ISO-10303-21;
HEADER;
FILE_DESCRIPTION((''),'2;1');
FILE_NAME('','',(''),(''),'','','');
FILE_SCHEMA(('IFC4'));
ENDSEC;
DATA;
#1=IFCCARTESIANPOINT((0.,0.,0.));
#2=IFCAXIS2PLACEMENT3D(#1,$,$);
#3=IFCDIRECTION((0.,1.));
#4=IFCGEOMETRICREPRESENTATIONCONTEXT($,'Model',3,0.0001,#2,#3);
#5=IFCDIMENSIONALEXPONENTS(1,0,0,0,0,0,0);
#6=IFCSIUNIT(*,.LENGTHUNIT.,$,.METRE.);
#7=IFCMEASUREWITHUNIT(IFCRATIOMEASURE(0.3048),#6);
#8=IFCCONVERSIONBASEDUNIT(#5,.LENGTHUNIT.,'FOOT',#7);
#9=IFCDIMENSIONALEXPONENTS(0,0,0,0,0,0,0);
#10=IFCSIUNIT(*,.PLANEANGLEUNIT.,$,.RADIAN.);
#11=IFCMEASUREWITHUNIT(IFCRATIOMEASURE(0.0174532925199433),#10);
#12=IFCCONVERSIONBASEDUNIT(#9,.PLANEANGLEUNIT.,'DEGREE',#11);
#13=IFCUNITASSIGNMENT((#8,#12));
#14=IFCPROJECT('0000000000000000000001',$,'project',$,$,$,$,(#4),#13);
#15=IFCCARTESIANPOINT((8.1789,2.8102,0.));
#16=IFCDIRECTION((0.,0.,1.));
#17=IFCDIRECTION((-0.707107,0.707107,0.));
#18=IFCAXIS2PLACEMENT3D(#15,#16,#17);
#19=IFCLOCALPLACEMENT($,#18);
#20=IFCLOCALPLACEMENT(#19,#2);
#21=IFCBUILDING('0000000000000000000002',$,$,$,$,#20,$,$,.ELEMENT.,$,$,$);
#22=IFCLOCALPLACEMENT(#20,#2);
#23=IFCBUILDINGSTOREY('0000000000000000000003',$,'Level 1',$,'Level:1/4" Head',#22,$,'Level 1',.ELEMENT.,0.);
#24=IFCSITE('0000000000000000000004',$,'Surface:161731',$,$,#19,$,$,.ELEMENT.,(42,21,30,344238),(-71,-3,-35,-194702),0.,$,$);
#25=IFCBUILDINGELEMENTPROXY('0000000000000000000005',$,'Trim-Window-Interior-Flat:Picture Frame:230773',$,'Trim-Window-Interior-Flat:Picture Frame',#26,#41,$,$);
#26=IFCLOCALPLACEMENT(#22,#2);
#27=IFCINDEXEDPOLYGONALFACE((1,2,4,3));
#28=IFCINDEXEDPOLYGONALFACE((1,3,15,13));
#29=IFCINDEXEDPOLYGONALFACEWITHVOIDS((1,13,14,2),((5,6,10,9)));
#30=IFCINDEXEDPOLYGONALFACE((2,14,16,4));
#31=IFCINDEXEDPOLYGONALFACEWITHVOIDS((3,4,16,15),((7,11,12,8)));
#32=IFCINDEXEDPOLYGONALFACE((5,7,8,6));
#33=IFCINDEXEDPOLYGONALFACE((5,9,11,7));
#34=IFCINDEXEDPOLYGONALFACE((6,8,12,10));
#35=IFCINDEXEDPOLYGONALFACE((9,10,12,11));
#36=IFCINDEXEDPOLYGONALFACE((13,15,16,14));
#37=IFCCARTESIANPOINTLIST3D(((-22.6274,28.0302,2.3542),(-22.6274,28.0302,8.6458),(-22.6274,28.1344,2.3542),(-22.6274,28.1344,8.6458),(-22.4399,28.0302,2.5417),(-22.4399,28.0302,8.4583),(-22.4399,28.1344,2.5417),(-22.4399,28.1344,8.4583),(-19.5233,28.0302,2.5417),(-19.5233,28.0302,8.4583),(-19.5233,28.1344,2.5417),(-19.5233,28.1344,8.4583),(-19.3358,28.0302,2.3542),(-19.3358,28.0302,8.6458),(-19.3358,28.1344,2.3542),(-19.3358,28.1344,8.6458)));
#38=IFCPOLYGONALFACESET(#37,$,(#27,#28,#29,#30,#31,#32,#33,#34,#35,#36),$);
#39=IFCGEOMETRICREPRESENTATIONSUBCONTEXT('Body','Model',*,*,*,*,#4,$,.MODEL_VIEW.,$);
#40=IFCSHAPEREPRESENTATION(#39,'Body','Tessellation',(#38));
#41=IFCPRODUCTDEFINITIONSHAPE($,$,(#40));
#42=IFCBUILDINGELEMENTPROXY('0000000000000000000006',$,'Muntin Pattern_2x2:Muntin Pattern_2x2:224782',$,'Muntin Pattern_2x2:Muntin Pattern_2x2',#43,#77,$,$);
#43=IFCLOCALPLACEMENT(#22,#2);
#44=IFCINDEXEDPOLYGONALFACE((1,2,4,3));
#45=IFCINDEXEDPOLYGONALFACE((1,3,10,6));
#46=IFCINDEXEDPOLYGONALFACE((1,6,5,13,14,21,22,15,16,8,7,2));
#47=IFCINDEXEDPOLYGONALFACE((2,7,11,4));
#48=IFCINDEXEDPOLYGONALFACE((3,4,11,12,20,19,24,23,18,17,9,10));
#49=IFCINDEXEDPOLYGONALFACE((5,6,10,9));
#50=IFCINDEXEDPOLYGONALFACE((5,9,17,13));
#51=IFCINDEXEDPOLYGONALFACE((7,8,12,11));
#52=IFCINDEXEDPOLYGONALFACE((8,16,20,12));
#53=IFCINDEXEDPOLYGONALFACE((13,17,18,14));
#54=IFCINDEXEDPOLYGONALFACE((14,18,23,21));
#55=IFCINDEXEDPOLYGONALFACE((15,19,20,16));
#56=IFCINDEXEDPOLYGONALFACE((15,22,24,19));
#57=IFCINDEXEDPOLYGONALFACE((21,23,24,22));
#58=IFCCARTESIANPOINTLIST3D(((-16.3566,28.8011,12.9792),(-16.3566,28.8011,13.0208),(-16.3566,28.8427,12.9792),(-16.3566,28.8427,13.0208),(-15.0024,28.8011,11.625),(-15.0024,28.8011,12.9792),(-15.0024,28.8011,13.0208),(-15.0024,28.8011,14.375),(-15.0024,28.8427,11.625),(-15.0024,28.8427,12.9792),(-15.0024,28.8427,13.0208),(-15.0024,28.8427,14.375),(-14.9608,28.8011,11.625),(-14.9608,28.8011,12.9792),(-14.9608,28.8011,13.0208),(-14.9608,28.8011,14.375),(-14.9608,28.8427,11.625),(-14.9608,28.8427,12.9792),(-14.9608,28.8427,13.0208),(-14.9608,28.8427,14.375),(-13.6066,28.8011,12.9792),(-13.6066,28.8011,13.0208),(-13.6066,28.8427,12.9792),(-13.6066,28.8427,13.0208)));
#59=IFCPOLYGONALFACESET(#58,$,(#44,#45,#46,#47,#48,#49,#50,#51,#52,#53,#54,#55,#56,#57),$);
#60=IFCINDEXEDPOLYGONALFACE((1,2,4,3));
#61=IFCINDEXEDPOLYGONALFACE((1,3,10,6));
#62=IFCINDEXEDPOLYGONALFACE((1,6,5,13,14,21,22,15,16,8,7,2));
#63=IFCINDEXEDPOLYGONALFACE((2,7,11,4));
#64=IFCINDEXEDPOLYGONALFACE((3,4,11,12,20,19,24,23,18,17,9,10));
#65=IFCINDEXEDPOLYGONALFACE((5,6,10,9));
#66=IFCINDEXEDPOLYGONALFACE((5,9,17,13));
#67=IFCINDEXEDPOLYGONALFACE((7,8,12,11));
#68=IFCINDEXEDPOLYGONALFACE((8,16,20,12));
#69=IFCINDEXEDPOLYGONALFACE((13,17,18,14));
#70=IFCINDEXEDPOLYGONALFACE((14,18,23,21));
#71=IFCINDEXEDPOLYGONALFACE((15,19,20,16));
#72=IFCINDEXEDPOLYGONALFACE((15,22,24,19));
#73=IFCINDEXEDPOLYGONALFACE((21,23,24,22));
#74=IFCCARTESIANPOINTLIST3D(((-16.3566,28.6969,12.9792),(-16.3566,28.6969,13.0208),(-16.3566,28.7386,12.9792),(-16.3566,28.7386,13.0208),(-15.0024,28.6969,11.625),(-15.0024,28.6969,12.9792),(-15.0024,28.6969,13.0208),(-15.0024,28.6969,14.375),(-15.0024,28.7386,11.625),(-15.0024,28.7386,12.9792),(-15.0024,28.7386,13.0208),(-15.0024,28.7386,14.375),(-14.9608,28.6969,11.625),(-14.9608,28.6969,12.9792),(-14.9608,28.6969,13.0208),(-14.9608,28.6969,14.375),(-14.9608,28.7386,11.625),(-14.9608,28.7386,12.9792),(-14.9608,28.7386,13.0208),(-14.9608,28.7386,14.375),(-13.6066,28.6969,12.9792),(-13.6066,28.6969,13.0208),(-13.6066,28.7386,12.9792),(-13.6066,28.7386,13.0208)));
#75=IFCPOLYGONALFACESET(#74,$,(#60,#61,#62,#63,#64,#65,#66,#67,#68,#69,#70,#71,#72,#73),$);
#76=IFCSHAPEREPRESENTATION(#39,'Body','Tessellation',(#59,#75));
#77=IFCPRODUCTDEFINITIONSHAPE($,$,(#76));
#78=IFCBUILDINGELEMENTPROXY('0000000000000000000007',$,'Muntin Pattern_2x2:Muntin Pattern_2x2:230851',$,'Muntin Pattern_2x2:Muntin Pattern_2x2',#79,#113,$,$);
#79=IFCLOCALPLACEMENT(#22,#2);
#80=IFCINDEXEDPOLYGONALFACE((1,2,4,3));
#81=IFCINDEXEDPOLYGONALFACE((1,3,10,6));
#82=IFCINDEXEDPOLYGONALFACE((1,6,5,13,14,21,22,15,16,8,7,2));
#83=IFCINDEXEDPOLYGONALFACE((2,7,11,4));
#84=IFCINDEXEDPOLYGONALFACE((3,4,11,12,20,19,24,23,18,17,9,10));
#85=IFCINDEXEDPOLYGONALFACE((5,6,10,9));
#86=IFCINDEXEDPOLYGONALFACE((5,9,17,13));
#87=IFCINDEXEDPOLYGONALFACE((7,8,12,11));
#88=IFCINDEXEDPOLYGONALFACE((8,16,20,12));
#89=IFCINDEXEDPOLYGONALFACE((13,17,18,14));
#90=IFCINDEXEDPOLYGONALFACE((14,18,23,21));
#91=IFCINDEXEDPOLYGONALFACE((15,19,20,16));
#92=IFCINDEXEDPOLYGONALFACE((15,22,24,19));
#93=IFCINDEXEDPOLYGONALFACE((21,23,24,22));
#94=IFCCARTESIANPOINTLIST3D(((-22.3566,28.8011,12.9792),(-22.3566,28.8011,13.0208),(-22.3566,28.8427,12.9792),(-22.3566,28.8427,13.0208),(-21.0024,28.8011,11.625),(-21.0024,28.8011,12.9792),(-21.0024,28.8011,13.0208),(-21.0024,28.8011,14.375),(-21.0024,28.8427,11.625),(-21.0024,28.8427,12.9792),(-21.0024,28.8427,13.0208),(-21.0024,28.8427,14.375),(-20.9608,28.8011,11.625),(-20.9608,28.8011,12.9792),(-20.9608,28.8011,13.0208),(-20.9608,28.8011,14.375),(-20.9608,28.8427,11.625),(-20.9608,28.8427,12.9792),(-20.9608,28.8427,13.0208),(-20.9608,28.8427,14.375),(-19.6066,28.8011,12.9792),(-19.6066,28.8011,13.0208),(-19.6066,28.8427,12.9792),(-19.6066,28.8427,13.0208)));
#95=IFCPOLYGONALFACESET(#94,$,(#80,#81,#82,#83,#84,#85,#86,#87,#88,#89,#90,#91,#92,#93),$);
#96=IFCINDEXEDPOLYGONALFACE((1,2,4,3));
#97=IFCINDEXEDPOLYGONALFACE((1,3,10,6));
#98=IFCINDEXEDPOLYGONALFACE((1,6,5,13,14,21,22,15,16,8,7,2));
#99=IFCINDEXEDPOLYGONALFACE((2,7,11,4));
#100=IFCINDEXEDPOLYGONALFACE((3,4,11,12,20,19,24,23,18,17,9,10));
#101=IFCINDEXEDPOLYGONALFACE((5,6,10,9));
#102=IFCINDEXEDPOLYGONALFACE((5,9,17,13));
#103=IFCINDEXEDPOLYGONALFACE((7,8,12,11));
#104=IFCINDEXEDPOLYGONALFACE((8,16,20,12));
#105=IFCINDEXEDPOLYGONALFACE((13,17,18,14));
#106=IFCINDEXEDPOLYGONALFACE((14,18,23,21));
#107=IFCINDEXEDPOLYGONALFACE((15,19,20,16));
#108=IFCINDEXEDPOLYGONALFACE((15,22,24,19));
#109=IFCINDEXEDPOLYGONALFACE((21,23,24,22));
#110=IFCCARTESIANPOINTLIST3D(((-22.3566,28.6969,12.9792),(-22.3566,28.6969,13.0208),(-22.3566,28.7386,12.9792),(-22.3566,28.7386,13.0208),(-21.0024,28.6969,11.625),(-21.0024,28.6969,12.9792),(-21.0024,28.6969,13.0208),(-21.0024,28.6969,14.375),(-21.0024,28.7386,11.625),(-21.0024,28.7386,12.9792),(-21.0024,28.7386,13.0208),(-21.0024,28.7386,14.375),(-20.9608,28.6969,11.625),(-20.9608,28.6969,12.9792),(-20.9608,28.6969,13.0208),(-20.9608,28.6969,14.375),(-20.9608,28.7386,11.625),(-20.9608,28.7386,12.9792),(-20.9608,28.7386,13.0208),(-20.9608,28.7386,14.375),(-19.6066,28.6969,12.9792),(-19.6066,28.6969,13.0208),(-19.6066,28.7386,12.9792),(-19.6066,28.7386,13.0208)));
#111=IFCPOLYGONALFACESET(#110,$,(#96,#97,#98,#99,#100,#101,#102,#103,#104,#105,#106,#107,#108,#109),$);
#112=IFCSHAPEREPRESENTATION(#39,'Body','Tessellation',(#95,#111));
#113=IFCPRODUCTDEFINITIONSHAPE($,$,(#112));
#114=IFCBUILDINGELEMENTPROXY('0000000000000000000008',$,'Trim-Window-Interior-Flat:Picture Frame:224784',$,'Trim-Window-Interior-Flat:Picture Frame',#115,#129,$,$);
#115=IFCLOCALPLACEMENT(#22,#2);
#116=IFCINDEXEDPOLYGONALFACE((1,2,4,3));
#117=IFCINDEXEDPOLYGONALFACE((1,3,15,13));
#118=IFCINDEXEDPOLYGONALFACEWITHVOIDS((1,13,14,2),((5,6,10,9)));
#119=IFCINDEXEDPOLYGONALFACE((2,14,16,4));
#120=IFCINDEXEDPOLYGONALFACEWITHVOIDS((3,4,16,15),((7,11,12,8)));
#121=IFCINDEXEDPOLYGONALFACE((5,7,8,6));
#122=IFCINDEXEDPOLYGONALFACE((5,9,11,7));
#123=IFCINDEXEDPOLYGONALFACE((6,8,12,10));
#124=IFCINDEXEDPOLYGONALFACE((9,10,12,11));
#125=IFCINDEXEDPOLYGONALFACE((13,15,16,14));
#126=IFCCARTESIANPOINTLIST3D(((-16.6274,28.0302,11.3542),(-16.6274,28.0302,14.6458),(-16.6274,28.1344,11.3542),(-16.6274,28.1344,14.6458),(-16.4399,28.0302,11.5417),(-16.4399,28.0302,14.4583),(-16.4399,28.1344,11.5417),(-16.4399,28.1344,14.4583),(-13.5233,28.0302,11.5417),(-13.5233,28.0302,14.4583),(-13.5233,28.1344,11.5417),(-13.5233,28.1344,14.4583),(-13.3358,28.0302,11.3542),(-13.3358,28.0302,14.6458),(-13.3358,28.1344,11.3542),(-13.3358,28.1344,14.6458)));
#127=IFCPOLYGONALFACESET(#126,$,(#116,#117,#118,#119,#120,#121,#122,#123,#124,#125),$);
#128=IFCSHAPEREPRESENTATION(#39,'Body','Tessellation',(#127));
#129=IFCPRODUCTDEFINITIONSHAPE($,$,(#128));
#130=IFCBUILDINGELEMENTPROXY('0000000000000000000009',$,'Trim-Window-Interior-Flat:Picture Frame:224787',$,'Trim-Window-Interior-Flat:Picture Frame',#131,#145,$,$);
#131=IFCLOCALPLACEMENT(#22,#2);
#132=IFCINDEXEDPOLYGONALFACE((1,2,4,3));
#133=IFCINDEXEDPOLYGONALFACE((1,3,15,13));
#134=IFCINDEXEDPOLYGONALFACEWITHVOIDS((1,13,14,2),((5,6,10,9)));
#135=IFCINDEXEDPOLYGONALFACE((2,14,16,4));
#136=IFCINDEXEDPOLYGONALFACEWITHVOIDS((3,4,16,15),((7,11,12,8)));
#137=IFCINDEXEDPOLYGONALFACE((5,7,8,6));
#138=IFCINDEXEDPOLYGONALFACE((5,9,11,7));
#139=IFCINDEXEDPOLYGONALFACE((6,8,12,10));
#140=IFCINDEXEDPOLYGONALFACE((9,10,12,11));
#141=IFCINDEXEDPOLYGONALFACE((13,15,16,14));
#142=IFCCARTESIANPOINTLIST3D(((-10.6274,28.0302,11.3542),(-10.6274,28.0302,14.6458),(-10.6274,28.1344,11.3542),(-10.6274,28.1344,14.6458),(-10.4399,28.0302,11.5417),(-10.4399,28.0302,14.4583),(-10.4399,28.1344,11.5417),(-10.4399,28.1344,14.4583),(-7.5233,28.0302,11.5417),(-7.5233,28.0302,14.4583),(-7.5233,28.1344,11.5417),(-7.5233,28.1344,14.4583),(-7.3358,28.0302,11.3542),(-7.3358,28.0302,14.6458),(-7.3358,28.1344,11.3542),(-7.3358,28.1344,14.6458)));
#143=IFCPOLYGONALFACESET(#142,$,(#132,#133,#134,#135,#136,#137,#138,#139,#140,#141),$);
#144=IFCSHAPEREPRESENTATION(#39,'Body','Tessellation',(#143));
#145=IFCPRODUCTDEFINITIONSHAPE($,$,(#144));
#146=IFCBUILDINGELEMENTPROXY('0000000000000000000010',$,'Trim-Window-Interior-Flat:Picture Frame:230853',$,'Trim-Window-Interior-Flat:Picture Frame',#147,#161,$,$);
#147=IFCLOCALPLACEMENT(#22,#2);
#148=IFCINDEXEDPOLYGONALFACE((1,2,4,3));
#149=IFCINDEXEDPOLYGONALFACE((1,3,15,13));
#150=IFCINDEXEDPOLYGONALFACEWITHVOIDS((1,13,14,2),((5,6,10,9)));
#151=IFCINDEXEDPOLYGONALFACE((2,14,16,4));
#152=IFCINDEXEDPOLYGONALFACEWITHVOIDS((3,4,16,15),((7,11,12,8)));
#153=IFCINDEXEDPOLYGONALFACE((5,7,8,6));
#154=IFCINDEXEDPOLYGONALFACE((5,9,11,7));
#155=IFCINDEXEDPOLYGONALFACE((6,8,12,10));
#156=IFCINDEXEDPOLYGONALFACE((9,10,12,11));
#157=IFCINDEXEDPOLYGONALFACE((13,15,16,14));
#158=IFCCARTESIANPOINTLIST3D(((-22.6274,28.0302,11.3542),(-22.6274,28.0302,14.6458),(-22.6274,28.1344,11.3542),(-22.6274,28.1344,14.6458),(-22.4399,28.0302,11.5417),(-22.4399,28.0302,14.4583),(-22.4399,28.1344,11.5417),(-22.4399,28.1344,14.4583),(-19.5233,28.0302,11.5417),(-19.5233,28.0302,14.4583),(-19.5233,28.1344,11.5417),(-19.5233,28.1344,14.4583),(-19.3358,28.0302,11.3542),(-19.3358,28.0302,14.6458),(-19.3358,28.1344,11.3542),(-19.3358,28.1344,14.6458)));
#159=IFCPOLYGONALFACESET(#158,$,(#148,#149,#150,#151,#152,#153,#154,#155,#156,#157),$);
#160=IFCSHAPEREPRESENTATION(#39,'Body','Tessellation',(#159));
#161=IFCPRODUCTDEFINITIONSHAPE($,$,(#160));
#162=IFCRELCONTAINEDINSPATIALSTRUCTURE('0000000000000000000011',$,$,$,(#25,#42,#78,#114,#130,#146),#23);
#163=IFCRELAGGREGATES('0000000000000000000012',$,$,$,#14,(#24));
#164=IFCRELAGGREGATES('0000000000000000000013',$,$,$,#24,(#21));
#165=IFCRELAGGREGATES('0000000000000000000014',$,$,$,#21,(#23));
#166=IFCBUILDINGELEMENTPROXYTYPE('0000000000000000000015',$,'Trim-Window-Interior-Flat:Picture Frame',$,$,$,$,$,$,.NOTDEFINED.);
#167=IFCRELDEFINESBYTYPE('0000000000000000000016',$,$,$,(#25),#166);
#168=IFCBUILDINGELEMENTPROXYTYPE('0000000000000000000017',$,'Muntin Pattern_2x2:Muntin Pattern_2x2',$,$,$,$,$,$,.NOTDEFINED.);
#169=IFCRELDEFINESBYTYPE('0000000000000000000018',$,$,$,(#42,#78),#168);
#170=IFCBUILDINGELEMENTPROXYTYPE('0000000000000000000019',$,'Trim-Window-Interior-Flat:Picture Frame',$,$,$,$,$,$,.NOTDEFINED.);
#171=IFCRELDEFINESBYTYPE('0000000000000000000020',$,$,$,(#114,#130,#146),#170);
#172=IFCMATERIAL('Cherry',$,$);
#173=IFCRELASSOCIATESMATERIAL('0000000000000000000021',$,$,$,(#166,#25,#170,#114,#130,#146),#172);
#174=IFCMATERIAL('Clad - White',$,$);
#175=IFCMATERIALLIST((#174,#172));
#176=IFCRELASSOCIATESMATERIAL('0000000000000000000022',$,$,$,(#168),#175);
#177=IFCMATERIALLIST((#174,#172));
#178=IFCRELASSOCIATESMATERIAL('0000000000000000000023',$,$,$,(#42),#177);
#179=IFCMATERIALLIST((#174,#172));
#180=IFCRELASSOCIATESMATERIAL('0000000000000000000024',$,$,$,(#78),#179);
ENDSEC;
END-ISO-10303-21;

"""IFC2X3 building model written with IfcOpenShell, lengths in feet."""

from ifc_helpers import new_model, entity, si_unit, converted_unit, direction, frame, origin, place, context, subcontext, project, spatial, polyline, outline, extrude, source, transform, mapped, material, material_list, type_object, type_shapes, element, save


model = new_model("IFC2X3")

# Units and contexts
model_context = context("Model", 3, precision=0.0001, world=origin(), true_north=direction((0.0, 1.0)))
body_context = subcontext(model_context, "Body", "Model", "MODEL_VIEW")
ifc_project = project(units=[converted_unit("LENGTHUNIT", "FOOT", entity("IfcRatioMeasure", 0.3048), si_unit("LENGTHUNIT", "METRE"), dimensions=[1, 0, 0, 0, 0, 0, 0]), converted_unit("PLANEANGLEUNIT", "DEGREE", entity("IfcRatioMeasure", 0.0174532925199433), si_unit("PLANEANGLEUNIT", "RADIAN"), dimensions=[0, 0, 0, 0, 0, 0, 0])], contexts=[model_context])

# Site, building, storey
site_placement = place(None, frame((8.1789, 2.8102, 0.0), z_axis=(0.0, 0.0, 1.0), x_axis=(-0.707107, 0.707107, 0.0)))
site = spatial("IfcSite", under=ifc_project, at=site_placement, Name="Surface:161731", CompositionType="ELEMENT", RefLatitude=(42, 21, 30, 344238), RefLongitude=(-71, -3, -35, -194702), RefElevation=0.0)
building_placement = place(site_placement, origin())
building = spatial("IfcBuilding", under=site, at=building_placement, CompositionType="ELEMENT")
storey_placement = place(building_placement, origin())
storey = spatial("IfcBuildingStorey", under=building, at=storey_placement, Name="Level 1", ObjectType="Level:1/4\" Head", LongName="Level 1", CompositionType="ELEMENT", Elevation=0.0)

# Building element proxies
ifc_material_1 = material(Name="Clad - White")
ifc_material_2 = material(Name="Cherry")
building_element_proxy_type_1 = type_object("IfcBuildingElementProxyType", Name="Trim-Window-Interior-Flat:Picture Frame", PredefinedType="NOTDEFINED", material=ifc_material_2)
shared_shape_1 = source(origin(), body_context, "Body", "SweptSolid", [
    extrude(outline(polyline([(-1.6458, -3.1458), (1.6458, -3.1458), (1.6458, 3.1458), (-1.6458, 3.1458), (-1.6458, -3.1458)]), holes=[polyline([(-1.4583, -2.9583), (-1.4583, 2.9583), (1.4583, 2.9583), (1.4583, -2.9583), (-1.4583, -2.9583)])]), frame((0.0, -3.0, 0.0), z_axis=(0.0, 0.0, 1.0), x_axis=(-1.0, 0.0, 0.0)), (0.0, 0.0, 1.0), 0.1042),
])
type_shapes(building_element_proxy_type_1, [shared_shape_1])
for number, where, z_axis, x_axis, name in (
    (1, (-20.9816, 28.1344, 8.5), (0.0, -1.0, 0.0), (1.0, 0.0, 0.0), "Trim-Window-Interior-Flat:Picture Frame:230773"),
):
    element("IfcBuildingElementProxy", number, at=place(storey_placement, frame(where, z_axis=z_axis, x_axis=x_axis)), inside=storey, type_object=building_element_proxy_type_1, material=ifc_material_2, Name=name, ObjectType="Trim-Window-Interior-Flat:Picture Frame", context=body_context, shape_type="MappedRepresentation", body=[
        mapped(shared_shape_1, transform((0.0, 0.0, 0.0), scale=1.0)),
    ])
ifc_material_list_1 = material_list([ifc_material_1, ifc_material_2])
ifc_material_list_2 = material_list([ifc_material_1, ifc_material_2])
building_element_proxy_type_2 = type_object("IfcBuildingElementProxyType", Name="Muntin Pattern_2x2:Muntin Pattern_2x2", PredefinedType="NOTDEFINED", material=ifc_material_list_2)
shared_shape_2 = source(origin(), body_context, "Body", "SweptSolid", [
    extrude(outline(polyline([(0.0208, -0.0208), (1.375, -0.0208), (1.375, 0.0208), (0.0208, 0.0208), (0.0208, 1.375), (-0.0208, 1.375), (-0.0208, 0.0208), (-1.375, 0.0208), (-1.375, -0.0208), (-0.0208, -0.0208), (-0.0208, -1.375), (0.0208, -1.375), (0.0208, -0.0208)])), frame((0.0, -0.0729, 1.375), z_axis=(0.0, 1.0, 0.0), x_axis=(0.0, 0.0, 1.0)), (0.0, 0.0, 1.0), 0.0417),
    extrude(outline(polyline([(0.0208, -0.0208), (1.375, -0.0208), (1.375, 0.0208), (0.0208, 0.0208), (0.0208, 1.375), (-0.0208, 1.375), (-0.0208, 0.0208), (-1.375, 0.0208), (-1.375, -0.0208), (-0.0208, -0.0208), (-0.0208, -1.375), (0.0208, -1.375), (0.0208, -0.0208)])), frame((0.0, 0.0313, 1.375), z_axis=(0.0, 1.0, 0.0), x_axis=(0.0, 0.0, 1.0)), (0.0, 0.0, 1.0), 0.0417),
])
type_shapes(building_element_proxy_type_2, [shared_shape_2])
proxy_1_placement = place(storey_placement, frame((-14.9816, 28.7698, 11.625), z_axis=(0.0, 0.0, 1.0), x_axis=(-1.0, 0.0, 0.0)))
element("IfcBuildingElementProxy", 2, at=proxy_1_placement, inside=storey, type_object=building_element_proxy_type_2, material=ifc_material_list_1, Name="Muntin Pattern_2x2:Muntin Pattern_2x2:224782", ObjectType="Muntin Pattern_2x2:Muntin Pattern_2x2", context=body_context, shape_type="MappedRepresentation", body=[
    mapped(shared_shape_2, transform((0.0, 0.0, 0.0), scale=1.0)),
])
ifc_material_list_3 = material_list([ifc_material_1, ifc_material_2])
proxy_2_placement = place(storey_placement, frame((-20.9816, 28.7698, 11.625), z_axis=(0.0, 0.0, 1.0), x_axis=(-1.0, 0.0, 0.0)))
element("IfcBuildingElementProxy", 3, at=proxy_2_placement, inside=storey, type_object=building_element_proxy_type_2, material=ifc_material_list_3, Name="Muntin Pattern_2x2:Muntin Pattern_2x2:230851", ObjectType="Muntin Pattern_2x2:Muntin Pattern_2x2", context=body_context, shape_type="MappedRepresentation", body=[
    mapped(shared_shape_2, transform((0.0, 0.0, 0.0), scale=1.0)),
])
building_element_proxy_type_3 = type_object("IfcBuildingElementProxyType", Name="Trim-Window-Interior-Flat:Picture Frame", PredefinedType="NOTDEFINED", material=ifc_material_2)
shared_shape_3 = source(origin(), body_context, "Body", "SweptSolid", [
    extrude(outline(polyline([(-1.6458, -1.6458), (1.6458, -1.6458), (1.6458, 1.6458), (-1.6458, 1.6458), (-1.6458, -1.6458)]), holes=[polyline([(-1.4583, -1.4583), (-1.4583, 1.4583), (1.4583, 1.4583), (1.4583, -1.4583), (-1.4583, -1.4583)])]), frame((0.0, -1.5, 0.0), z_axis=(0.0, 0.0, 1.0), x_axis=(-1.0, 0.0, 0.0)), (0.0, 0.0, 1.0), 0.1042),
])
type_shapes(building_element_proxy_type_3, [shared_shape_3])
for number, where, z_axis, x_axis, name in (
    (4, (-14.9816, 28.1344, 14.5), (0.0, -1.0, 0.0), (1.0, 0.0, 0.0), "Trim-Window-Interior-Flat:Picture Frame:224784"),
    (5, (-8.9816, 28.1344, 14.5), (0.0, -1.0, 0.0), (1.0, 0.0, 0.0), "Trim-Window-Interior-Flat:Picture Frame:224787"),
    (6, (-20.9816, 28.1344, 14.5), (0.0, -1.0, 0.0), (1.0, 0.0, 0.0), "Trim-Window-Interior-Flat:Picture Frame:230853"),
):
    element("IfcBuildingElementProxy", number, at=place(storey_placement, frame(where, z_axis=z_axis, x_axis=x_axis)), inside=storey, type_object=building_element_proxy_type_3, material=ifc_material_2, Name=name, ObjectType="Trim-Window-Interior-Flat:Picture Frame", context=body_context, shape_type="MappedRepresentation", body=[
        mapped(shared_shape_3, transform((0.0, 0.0, 0.0), scale=1.0)),
    ])

save(model, "model.ifc")
